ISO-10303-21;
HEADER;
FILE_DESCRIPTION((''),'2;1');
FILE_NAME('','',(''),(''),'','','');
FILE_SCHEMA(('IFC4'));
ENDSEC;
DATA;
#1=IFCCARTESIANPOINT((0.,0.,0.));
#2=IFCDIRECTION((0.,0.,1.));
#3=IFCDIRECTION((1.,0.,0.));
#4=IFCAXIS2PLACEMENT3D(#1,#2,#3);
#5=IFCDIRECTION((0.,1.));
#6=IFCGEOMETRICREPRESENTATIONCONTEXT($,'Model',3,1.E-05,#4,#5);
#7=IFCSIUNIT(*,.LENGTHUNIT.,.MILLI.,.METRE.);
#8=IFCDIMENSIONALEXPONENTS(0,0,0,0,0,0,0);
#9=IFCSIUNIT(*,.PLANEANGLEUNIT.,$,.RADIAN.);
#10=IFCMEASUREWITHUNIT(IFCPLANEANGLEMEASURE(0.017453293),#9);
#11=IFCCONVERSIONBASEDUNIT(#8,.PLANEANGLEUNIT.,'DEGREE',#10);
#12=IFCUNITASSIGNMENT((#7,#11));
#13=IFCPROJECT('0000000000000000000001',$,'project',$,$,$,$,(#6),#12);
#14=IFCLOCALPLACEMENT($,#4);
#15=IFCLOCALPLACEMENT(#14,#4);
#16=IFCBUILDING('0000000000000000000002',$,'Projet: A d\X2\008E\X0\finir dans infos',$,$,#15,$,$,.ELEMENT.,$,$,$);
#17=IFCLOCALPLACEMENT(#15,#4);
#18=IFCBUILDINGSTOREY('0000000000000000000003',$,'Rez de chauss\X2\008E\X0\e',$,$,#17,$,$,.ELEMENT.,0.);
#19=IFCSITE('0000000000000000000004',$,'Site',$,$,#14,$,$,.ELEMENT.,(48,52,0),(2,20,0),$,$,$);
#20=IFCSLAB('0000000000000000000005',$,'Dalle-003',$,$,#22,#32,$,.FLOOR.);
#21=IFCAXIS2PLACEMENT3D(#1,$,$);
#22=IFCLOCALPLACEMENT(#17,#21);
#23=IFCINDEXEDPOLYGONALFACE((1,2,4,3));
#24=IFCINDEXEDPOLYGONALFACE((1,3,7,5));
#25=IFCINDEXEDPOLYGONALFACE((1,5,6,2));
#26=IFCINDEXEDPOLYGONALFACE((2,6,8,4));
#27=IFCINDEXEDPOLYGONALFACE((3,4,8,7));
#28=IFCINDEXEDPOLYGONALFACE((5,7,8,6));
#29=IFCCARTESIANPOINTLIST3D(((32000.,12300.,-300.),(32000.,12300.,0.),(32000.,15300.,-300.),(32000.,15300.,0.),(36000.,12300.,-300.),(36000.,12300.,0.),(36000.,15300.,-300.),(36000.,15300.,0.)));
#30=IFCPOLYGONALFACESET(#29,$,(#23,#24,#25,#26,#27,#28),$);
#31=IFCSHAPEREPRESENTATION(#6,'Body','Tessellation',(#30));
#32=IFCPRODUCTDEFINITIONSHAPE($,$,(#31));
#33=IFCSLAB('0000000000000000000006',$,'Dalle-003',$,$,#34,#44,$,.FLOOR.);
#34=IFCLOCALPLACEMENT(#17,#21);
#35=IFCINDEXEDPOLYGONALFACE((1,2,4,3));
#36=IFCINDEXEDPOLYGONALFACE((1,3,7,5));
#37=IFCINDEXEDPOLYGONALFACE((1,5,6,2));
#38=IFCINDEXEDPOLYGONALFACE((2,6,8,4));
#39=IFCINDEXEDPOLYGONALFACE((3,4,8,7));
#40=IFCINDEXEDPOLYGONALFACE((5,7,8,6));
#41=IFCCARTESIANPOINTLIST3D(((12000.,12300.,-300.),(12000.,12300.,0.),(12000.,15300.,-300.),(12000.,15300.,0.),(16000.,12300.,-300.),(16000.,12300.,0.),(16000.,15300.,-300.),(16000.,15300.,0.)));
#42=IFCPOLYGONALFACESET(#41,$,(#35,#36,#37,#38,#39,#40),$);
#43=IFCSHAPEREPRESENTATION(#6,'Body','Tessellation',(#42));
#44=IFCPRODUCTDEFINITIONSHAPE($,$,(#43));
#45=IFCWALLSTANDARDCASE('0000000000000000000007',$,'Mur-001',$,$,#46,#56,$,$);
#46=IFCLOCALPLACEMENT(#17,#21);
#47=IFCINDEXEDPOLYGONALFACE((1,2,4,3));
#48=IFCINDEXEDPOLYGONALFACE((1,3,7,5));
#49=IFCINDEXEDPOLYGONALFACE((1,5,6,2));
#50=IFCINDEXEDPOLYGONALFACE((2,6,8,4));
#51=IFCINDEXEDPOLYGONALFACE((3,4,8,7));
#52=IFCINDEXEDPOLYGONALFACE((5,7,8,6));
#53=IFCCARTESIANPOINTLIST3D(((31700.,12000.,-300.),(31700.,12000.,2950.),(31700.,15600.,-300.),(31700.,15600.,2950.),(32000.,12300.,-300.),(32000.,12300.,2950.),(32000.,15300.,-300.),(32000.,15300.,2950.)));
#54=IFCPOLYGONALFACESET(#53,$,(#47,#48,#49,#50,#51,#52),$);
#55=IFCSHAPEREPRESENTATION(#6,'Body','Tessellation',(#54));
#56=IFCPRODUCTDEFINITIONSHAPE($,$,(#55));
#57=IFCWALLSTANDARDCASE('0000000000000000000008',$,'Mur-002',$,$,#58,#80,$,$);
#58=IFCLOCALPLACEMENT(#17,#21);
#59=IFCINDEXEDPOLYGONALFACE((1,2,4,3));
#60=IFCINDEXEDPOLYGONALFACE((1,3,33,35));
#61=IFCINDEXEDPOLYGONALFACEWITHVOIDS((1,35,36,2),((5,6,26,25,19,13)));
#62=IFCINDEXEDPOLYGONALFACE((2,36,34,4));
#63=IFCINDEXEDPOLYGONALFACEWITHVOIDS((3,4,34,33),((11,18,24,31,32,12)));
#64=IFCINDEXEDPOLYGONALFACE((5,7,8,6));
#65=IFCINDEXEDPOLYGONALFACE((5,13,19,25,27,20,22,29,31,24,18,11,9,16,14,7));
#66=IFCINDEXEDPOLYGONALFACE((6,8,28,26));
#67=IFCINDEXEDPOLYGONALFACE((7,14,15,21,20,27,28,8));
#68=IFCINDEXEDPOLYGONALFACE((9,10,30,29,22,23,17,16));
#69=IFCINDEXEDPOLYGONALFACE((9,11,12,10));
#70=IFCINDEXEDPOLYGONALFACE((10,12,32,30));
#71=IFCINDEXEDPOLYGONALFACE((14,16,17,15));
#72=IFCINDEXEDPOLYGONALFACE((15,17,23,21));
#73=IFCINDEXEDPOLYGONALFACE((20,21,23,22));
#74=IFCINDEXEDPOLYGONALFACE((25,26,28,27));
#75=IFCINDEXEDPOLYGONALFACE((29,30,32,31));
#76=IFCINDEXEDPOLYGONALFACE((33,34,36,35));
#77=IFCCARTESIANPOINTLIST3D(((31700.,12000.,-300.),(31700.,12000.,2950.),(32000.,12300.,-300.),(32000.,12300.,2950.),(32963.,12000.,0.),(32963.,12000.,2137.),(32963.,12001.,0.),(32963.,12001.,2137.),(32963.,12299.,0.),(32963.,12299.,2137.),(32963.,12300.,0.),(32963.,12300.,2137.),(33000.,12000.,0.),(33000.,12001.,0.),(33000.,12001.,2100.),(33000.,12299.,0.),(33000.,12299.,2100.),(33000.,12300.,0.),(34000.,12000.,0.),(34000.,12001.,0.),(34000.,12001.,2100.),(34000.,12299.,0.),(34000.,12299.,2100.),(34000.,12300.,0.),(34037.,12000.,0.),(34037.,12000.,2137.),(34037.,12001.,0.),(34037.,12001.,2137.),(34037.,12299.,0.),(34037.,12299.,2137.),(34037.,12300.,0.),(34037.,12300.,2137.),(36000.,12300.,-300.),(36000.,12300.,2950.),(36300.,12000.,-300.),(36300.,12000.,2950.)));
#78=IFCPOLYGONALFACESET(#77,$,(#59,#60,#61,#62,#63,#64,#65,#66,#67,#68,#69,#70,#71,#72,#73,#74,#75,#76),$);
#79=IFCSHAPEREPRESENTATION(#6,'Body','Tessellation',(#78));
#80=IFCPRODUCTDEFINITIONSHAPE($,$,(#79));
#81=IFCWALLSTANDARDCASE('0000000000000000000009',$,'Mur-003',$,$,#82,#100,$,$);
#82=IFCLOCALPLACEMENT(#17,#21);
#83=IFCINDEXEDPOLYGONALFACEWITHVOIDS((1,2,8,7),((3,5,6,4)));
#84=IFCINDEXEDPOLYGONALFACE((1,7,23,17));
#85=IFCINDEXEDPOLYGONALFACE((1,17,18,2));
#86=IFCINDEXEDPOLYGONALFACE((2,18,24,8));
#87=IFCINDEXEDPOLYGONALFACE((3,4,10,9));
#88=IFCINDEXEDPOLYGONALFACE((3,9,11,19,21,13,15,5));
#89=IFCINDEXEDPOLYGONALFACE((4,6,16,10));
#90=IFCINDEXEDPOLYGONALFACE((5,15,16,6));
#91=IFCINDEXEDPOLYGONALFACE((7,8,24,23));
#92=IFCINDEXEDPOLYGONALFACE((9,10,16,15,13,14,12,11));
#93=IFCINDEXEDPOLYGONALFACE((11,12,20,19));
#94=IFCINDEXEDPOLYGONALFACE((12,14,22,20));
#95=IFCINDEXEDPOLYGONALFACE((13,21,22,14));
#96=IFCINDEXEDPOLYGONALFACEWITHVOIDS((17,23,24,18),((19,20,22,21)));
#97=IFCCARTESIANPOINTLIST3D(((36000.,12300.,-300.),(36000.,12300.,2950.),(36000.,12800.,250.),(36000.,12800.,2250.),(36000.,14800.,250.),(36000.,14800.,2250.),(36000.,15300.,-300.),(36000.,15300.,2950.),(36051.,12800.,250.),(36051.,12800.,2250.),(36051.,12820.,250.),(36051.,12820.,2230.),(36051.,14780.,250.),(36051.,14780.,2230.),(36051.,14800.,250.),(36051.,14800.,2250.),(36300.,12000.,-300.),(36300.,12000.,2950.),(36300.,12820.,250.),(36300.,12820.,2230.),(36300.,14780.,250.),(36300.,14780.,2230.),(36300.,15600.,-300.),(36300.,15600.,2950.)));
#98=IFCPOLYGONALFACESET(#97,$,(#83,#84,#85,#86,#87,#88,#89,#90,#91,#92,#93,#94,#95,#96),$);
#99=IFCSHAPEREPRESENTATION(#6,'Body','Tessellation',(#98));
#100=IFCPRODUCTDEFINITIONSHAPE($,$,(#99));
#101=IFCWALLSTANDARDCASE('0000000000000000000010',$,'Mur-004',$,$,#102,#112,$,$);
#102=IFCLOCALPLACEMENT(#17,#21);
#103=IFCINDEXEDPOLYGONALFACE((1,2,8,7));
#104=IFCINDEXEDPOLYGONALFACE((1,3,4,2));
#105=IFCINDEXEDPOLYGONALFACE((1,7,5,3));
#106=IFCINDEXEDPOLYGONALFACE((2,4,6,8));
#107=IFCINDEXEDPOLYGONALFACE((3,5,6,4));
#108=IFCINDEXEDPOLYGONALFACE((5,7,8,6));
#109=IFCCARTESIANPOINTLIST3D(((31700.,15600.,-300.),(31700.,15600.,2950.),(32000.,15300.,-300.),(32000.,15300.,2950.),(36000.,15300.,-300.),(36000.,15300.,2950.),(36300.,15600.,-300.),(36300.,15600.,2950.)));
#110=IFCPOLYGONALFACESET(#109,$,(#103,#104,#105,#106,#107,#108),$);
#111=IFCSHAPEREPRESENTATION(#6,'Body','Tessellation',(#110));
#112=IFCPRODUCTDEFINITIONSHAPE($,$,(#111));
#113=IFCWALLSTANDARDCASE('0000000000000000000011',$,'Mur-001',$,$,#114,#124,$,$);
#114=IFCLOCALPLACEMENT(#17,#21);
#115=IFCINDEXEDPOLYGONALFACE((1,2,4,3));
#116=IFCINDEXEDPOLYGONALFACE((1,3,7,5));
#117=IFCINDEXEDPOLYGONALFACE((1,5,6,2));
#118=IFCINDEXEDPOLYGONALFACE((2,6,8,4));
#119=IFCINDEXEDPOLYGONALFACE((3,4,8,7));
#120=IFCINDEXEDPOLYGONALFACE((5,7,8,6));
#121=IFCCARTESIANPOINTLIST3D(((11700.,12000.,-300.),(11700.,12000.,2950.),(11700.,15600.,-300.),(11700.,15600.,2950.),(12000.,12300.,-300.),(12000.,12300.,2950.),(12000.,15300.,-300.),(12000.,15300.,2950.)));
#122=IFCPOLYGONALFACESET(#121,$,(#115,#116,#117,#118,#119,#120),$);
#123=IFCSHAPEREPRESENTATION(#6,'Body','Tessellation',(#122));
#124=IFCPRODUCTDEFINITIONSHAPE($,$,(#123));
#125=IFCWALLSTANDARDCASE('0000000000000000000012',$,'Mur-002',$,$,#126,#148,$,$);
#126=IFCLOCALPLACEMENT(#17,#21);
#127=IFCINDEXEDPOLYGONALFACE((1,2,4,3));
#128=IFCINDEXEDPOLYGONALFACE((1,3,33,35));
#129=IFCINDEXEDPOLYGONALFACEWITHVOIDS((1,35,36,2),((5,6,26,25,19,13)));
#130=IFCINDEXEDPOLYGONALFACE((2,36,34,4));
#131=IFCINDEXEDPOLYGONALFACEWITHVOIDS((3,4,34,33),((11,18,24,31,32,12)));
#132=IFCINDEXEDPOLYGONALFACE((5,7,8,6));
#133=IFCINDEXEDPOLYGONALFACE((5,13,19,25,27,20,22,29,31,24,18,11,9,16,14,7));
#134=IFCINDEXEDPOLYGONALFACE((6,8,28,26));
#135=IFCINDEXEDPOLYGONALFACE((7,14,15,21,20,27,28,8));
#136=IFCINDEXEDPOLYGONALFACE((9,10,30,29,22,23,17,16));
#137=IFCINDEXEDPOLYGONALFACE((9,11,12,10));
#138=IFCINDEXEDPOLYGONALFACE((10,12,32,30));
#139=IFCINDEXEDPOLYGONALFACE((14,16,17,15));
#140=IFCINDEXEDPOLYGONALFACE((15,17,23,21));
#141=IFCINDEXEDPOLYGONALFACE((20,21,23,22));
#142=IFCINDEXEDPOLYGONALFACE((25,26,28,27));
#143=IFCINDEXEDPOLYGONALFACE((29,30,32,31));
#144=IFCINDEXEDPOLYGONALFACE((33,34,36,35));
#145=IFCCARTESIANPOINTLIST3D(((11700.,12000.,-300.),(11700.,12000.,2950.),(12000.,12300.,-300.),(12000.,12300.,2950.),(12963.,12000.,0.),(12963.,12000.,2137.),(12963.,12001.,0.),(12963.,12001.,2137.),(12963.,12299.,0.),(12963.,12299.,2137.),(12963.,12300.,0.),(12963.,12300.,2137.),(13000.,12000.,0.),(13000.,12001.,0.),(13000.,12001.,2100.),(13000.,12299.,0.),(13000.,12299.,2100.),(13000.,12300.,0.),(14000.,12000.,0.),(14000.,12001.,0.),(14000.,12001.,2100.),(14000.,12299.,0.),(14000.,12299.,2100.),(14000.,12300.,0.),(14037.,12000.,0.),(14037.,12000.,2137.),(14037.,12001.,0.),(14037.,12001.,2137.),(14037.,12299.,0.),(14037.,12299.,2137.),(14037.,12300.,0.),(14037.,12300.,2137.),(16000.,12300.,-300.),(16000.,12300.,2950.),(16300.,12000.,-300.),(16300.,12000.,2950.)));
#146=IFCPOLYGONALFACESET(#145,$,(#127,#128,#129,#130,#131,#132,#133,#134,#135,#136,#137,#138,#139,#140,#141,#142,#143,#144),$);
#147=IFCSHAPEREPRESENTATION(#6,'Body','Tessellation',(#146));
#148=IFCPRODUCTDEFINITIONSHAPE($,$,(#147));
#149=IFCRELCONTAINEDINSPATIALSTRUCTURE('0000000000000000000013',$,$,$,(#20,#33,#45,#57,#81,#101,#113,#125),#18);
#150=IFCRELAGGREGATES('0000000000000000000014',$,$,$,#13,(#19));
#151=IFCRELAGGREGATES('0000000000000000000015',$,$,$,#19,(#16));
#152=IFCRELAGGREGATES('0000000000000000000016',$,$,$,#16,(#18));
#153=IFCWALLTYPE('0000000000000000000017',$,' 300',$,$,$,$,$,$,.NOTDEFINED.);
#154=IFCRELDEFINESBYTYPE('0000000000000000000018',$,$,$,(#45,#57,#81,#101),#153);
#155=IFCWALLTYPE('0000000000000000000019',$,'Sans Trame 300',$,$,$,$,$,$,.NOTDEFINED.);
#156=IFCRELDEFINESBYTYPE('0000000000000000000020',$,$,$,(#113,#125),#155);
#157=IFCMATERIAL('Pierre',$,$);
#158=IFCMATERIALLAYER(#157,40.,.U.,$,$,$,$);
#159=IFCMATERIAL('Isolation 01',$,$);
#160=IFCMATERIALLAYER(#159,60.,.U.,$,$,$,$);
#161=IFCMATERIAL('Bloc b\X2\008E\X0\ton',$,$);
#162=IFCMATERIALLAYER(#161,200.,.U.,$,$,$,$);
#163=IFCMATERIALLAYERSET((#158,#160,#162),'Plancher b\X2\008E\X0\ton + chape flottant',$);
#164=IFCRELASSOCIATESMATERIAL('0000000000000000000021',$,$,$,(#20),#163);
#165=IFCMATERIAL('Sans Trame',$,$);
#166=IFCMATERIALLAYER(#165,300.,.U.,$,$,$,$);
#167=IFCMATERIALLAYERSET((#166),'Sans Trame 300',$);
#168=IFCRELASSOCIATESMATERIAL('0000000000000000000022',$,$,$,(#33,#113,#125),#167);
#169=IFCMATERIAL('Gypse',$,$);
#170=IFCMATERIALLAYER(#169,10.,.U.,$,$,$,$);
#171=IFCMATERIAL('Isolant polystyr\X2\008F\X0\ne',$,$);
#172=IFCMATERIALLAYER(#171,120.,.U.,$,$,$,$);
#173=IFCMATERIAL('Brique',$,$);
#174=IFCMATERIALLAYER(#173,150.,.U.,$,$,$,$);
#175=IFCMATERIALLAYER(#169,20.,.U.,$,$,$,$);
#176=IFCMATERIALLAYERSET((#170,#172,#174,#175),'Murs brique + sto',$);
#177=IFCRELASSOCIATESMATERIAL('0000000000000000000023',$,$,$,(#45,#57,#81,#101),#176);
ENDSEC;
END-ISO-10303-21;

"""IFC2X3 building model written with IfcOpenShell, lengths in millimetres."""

from ifc_helpers import new_model, entity, si_unit, converted_unit, direction, frame, origin_with_axes, origin_2d_with_axis, place, context, project, spatial, polyline, rectangle, outline, extrude, material, layer, layer_set, layer_usage, type_object, element, save


model = new_model("IFC2X3")

# Units and contexts
model_context = context("Model", 3, precision=1e-05, world=origin_with_axes(), true_north=direction((0.0, 1.0)))
ifc_project = project(units=[si_unit("LENGTHUNIT", "METRE", prefix="MILLI"), converted_unit("PLANEANGLEUNIT", "DEGREE", entity("IfcPlaneAngleMeasure", 0.017453293), si_unit("PLANEANGLEUNIT", "RADIAN"), dimensions=[0, 0, 0, 0, 0, 0, 0])], contexts=[model_context])

# Site, building, storey
site_placement = place(None, origin_with_axes())
site = spatial("IfcSite", under=ifc_project, at=site_placement, Name="Site", CompositionType="ELEMENT", RefLatitude=(48, 52, 0), RefLongitude=(2, 20, 0))
building_placement = place(site_placement, origin_with_axes())
building = spatial("IfcBuilding", under=site, at=building_placement, Name="Projet: A d\u008efinir dans infos", CompositionType="ELEMENT")
storey_placement = place(building_placement, origin_with_axes())
storey = spatial("IfcBuildingStorey", under=building, at=storey_placement, Name="Rez de chauss\u008ee", CompositionType="ELEMENT", Elevation=0.0)

# Slabs
ifc_material_1 = material(Name="Pierre")
ifc_layer_1 = layer(ifc_material_1, 40.0, ventilated="UNKNOWN")
ifc_material_2 = material(Name="Isolation 01")
ifc_layer_2 = layer(ifc_material_2, 60.0, ventilated="UNKNOWN")
ifc_material_3 = material(Name="Bloc b\u008eton")
ifc_layer_3 = layer(ifc_material_3, 200.0, ventilated="UNKNOWN")
ifc_layer_set_1 = layer_set([ifc_layer_1, ifc_layer_2, ifc_layer_3], Name="Plancher b\u008eton + chape flottant")
ifc_layer_usage_1 = layer_usage(ifc_layer_set_1, "AXIS3", "NEGATIVE", 300.0)
slab_1_placement = place(storey_placement, frame((32000.0, 15300.0, -300.0), z_axis=(0.0, 0.0, 1.0), x_axis=(1.0, 0.0, 0.0)))
element("IfcSlab", 1, at=slab_1_placement, inside=storey, material=ifc_layer_usage_1, Name="Dalle-003", PredefinedType="FLOOR", context=model_context, shape_type="SweptSolid", body=[
    extrude(outline(polyline([(0.0, 0.0), (0.0, -3000.0), (4000.0, -3000.0), (4000.0, 0.0), (0.0, 0.0)])), origin_with_axes(), (0.0, 0.0, 1.0), 300.0),
])
ifc_material_4 = material(Name="Sans Trame")
ifc_layer_4 = layer(ifc_material_4, 300.0, ventilated="UNKNOWN")
ifc_layer_set_2 = layer_set([ifc_layer_4], Name="Sans Trame 300")
ifc_layer_usage_2 = layer_usage(ifc_layer_set_2, "AXIS3", "NEGATIVE", 300.0)
slab_2_placement = place(storey_placement, frame((12000.0, 15300.0, -300.0), z_axis=(0.0, 0.0, 1.0), x_axis=(1.0, 0.0, 0.0)))
element("IfcSlab", 2, at=slab_2_placement, inside=storey, material=ifc_layer_usage_2, Name="Dalle-003", PredefinedType="FLOOR", context=model_context, shape_type="SweptSolid", body=[
    extrude(outline(polyline([(0.0, 0.0), (0.0, -3000.0), (4000.0, -3000.0), (4000.0, 0.0), (0.0, 0.0)])), origin_with_axes(), (0.0, 0.0, 1.0), 300.0),
])

# Wall
ifc_material_5 = material(Name="Gypse")
ifc_layer_5 = layer(ifc_material_5, 10.0, ventilated="UNKNOWN")
ifc_material_6 = material(Name="Isolant polystyr\u008fne")
ifc_layer_6 = layer(ifc_material_6, 120.0, ventilated="UNKNOWN")
ifc_material_7 = material(Name="Brique")
ifc_layer_7 = layer(ifc_material_7, 150.0, ventilated="UNKNOWN")
ifc_layer_8 = layer(ifc_material_5, 20.0, ventilated="UNKNOWN")
ifc_layer_set_3 = layer_set([ifc_layer_5, ifc_layer_6, ifc_layer_7, ifc_layer_8], Name="Murs brique + sto")
ifc_layer_usage_3 = layer_usage(ifc_layer_set_3, "AXIS2", "POSITIVE", 0.0)
wall_type_1 = type_object("IfcWallType", Name=" 300", PredefinedType="NOTDEFINED")
wall_1_placement = place(storey_placement, frame((31700.0, 15600.0, -300.0), z_axis=(0.0, 0.0, 1.0), x_axis=(0.0, -1.0, 0.0)))
element("IfcWallStandardCase", 3, at=wall_1_placement, inside=storey, type_object=wall_type_1, material=ifc_layer_usage_3, Name="Mur-001", context=model_context, shape_type="SweptSolid", body=[
    extrude(outline(polyline([(0.0, 0.0), (3600.0, 0.0), (3300.0, 300.0), (300.0, 300.0), (0.0, 0.0)])), origin_with_axes(), (0.0, 0.0, 1.0), 3250.0),
])

# Walls, openings
ifc_layer_usage_4 = layer_usage(ifc_layer_set_3, "AXIS2", "POSITIVE", 0.0)
wall_2_placement = place(storey_placement, frame((31700.0, 12000.0, -300.0), z_axis=(0.0, 0.0, 1.0), x_axis=(1.0, 0.0, 0.0)))
wall_2 = element("IfcWallStandardCase", 4, at=wall_2_placement, inside=storey, type_object=wall_type_1, material=ifc_layer_usage_4, Name="Mur-002", context=model_context, shape_type="SweptSolid", body=[
    extrude(outline(polyline([(0.0, 0.0), (4600.0, 0.0), (4300.0, 300.0), (300.0, 300.0), (0.0, 0.0)])), origin_with_axes(), (0.0, 0.0, 1.0), 3250.0),
])
opening_1_placement = place(wall_2_placement, frame((1800.0, 0.0, 300.0), z_axis=(0.0, 0.0, 1.0), x_axis=(1.0, 0.0, 0.0)))
element("IfcOpeningElement", 5, at=opening_1_placement, cuts=wall_2, context=model_context, shape_type="SweptSolid", body=[
    extrude(rectangle(XDim=1000.0, YDim=2100.0, at=origin_2d_with_axis()), frame((0.0, -1.0, 1050.0), z_axis=(0.0, 1.0, 0.0), x_axis=(1.0, 0.0, 0.0)), (0.0, 0.0, 1.0), 902.0),
    extrude(rectangle(XDim=1074.0, YDim=2137.0, at=origin_2d_with_axis()), frame((0.0, -601.0, 1068.5), z_axis=(0.0, 1.0, 0.0), x_axis=(1.0, 0.0, 0.0)), (0.0, 0.0, 1.0), 602.0),
    extrude(rectangle(XDim=1074.0, YDim=2137.0, at=origin_2d_with_axis()), frame((0.0, 901.0, 1068.5), z_axis=(0.0, -1.0, 0.0), x_axis=(1.0, 0.0, 0.0)), (0.0, 0.0, 1.0), 602.0),
])
ifc_layer_usage_5 = layer_usage(ifc_layer_set_3, "AXIS2", "POSITIVE", 0.0)
wall_3_placement = place(storey_placement, frame((36300.0, 12000.0, -300.0), z_axis=(0.0, 0.0, 1.0), x_axis=(0.0, 1.0, 0.0)))
wall_3 = element("IfcWallStandardCase", 6, at=wall_3_placement, inside=storey, type_object=wall_type_1, material=ifc_layer_usage_5, Name="Mur-003", context=model_context, shape_type="SweptSolid", body=[
    extrude(outline(polyline([(0.0, 0.0), (3600.0, 0.0), (3300.0, 300.0), (300.0, 300.0), (0.0, 0.0)])), origin_with_axes(), (0.0, 0.0, 1.0), 3250.0),
])
opening_2_placement = place(wall_3_placement, frame((1800.0, 0.0, 550.0), z_axis=(0.0, 0.0, 1.0), x_axis=(1.0, 0.0, 0.0)))
element("IfcOpeningElement", 7, at=opening_2_placement, cuts=wall_3, context=model_context, shape_type="SweptSolid", body=[
    extrude(rectangle(XDim=1960.0, YDim=1980.0, at=origin_2d_with_axis()), frame((0.0, -601.0, 990.0), z_axis=(0.0, 1.0, 0.0), x_axis=(1.0, 0.0, 0.0)), (0.0, 0.0, 1.0), 852.0),
    extrude(rectangle(XDim=2000.0, YDim=2000.0, at=origin_2d_with_axis()), frame((0.0, 901.0, 1000.0), z_axis=(0.0, -1.0, 0.0), x_axis=(1.0, 0.0, 0.0)), (0.0, 0.0, 1.0), 652.0),
])

# Walls
ifc_layer_usage_6 = layer_usage(ifc_layer_set_3, "AXIS2", "POSITIVE", 0.0)
wall_4_placement = place(storey_placement, frame((36300.0, 15600.0, -300.0), z_axis=(0.0, 0.0, 1.0), x_axis=(-1.0, 0.0, 0.0)))
element("IfcWallStandardCase", 8, at=wall_4_placement, inside=storey, type_object=wall_type_1, material=ifc_layer_usage_6, Name="Mur-004", context=model_context, shape_type="SweptSolid", body=[
    extrude(outline(polyline([(0.0, 0.0), (4600.0, 0.0), (4300.0, 300.0), (300.0, 300.0), (0.0, 0.0)])), origin_with_axes(), (0.0, 0.0, 1.0), 3250.0),
])
ifc_layer_usage_7 = layer_usage(ifc_layer_set_2, "AXIS2", "POSITIVE", 0.0)
wall_type_2 = type_object("IfcWallType", Name="Sans Trame 300", PredefinedType="NOTDEFINED")
wall_5_placement = place(storey_placement, frame((11700.0, 15600.0, -300.0), z_axis=(0.0, 0.0, 1.0), x_axis=(0.0, -1.0, 0.0)))
element("IfcWallStandardCase", 9, at=wall_5_placement, inside=storey, type_object=wall_type_2, material=ifc_layer_usage_7, Name="Mur-001", context=model_context, shape_type="SweptSolid", body=[
    extrude(outline(polyline([(0.0, 0.0), (3600.0, 0.0), (3300.0, 300.0), (300.0, 300.0), (0.0, 0.0)])), origin_with_axes(), (0.0, 0.0, 1.0), 3250.0),
])

# Wall, opening
ifc_layer_usage_8 = layer_usage(ifc_layer_set_2, "AXIS2", "POSITIVE", 0.0)
wall_6_placement = place(storey_placement, frame((11700.0, 12000.0, -300.0), z_axis=(0.0, 0.0, 1.0), x_axis=(1.0, 0.0, 0.0)))
wall_6 = element("IfcWallStandardCase", 10, at=wall_6_placement, inside=storey, type_object=wall_type_2, material=ifc_layer_usage_8, Name="Mur-002", context=model_context, shape_type="SweptSolid", body=[
    extrude(outline(polyline([(0.0, 0.0), (4600.0, 0.0), (4300.0, 300.0), (300.0, 300.0), (0.0, 0.0)])), origin_with_axes(), (0.0, 0.0, 1.0), 3250.0),
])
opening_3_placement = place(wall_6_placement, frame((1800.0, 0.0, 300.0), z_axis=(0.0, 0.0, 1.0), x_axis=(1.0, 0.0, 0.0)))
element("IfcOpeningElement", 11, at=opening_3_placement, cuts=wall_6, context=model_context, shape_type="SweptSolid", body=[
    extrude(rectangle(XDim=1000.0, YDim=2100.0, at=origin_2d_with_axis()), frame((0.0, -1.0, 1050.0), z_axis=(0.0, 1.0, 0.0), x_axis=(1.0, 0.0, 0.0)), (0.0, 0.0, 1.0), 902.0),
    extrude(rectangle(XDim=1074.0, YDim=2137.0, at=origin_2d_with_axis()), frame((0.0, -601.0, 1068.5), z_axis=(0.0, 1.0, 0.0), x_axis=(1.0, 0.0, 0.0)), (0.0, 0.0, 1.0), 602.0),
    extrude(rectangle(XDim=1074.0, YDim=2137.0, at=origin_2d_with_axis()), frame((0.0, 901.0, 1068.5), z_axis=(0.0, -1.0, 0.0), x_axis=(1.0, 0.0, 0.0)), (0.0, 0.0, 1.0), 602.0),
])

save(model, "model.ifc")
